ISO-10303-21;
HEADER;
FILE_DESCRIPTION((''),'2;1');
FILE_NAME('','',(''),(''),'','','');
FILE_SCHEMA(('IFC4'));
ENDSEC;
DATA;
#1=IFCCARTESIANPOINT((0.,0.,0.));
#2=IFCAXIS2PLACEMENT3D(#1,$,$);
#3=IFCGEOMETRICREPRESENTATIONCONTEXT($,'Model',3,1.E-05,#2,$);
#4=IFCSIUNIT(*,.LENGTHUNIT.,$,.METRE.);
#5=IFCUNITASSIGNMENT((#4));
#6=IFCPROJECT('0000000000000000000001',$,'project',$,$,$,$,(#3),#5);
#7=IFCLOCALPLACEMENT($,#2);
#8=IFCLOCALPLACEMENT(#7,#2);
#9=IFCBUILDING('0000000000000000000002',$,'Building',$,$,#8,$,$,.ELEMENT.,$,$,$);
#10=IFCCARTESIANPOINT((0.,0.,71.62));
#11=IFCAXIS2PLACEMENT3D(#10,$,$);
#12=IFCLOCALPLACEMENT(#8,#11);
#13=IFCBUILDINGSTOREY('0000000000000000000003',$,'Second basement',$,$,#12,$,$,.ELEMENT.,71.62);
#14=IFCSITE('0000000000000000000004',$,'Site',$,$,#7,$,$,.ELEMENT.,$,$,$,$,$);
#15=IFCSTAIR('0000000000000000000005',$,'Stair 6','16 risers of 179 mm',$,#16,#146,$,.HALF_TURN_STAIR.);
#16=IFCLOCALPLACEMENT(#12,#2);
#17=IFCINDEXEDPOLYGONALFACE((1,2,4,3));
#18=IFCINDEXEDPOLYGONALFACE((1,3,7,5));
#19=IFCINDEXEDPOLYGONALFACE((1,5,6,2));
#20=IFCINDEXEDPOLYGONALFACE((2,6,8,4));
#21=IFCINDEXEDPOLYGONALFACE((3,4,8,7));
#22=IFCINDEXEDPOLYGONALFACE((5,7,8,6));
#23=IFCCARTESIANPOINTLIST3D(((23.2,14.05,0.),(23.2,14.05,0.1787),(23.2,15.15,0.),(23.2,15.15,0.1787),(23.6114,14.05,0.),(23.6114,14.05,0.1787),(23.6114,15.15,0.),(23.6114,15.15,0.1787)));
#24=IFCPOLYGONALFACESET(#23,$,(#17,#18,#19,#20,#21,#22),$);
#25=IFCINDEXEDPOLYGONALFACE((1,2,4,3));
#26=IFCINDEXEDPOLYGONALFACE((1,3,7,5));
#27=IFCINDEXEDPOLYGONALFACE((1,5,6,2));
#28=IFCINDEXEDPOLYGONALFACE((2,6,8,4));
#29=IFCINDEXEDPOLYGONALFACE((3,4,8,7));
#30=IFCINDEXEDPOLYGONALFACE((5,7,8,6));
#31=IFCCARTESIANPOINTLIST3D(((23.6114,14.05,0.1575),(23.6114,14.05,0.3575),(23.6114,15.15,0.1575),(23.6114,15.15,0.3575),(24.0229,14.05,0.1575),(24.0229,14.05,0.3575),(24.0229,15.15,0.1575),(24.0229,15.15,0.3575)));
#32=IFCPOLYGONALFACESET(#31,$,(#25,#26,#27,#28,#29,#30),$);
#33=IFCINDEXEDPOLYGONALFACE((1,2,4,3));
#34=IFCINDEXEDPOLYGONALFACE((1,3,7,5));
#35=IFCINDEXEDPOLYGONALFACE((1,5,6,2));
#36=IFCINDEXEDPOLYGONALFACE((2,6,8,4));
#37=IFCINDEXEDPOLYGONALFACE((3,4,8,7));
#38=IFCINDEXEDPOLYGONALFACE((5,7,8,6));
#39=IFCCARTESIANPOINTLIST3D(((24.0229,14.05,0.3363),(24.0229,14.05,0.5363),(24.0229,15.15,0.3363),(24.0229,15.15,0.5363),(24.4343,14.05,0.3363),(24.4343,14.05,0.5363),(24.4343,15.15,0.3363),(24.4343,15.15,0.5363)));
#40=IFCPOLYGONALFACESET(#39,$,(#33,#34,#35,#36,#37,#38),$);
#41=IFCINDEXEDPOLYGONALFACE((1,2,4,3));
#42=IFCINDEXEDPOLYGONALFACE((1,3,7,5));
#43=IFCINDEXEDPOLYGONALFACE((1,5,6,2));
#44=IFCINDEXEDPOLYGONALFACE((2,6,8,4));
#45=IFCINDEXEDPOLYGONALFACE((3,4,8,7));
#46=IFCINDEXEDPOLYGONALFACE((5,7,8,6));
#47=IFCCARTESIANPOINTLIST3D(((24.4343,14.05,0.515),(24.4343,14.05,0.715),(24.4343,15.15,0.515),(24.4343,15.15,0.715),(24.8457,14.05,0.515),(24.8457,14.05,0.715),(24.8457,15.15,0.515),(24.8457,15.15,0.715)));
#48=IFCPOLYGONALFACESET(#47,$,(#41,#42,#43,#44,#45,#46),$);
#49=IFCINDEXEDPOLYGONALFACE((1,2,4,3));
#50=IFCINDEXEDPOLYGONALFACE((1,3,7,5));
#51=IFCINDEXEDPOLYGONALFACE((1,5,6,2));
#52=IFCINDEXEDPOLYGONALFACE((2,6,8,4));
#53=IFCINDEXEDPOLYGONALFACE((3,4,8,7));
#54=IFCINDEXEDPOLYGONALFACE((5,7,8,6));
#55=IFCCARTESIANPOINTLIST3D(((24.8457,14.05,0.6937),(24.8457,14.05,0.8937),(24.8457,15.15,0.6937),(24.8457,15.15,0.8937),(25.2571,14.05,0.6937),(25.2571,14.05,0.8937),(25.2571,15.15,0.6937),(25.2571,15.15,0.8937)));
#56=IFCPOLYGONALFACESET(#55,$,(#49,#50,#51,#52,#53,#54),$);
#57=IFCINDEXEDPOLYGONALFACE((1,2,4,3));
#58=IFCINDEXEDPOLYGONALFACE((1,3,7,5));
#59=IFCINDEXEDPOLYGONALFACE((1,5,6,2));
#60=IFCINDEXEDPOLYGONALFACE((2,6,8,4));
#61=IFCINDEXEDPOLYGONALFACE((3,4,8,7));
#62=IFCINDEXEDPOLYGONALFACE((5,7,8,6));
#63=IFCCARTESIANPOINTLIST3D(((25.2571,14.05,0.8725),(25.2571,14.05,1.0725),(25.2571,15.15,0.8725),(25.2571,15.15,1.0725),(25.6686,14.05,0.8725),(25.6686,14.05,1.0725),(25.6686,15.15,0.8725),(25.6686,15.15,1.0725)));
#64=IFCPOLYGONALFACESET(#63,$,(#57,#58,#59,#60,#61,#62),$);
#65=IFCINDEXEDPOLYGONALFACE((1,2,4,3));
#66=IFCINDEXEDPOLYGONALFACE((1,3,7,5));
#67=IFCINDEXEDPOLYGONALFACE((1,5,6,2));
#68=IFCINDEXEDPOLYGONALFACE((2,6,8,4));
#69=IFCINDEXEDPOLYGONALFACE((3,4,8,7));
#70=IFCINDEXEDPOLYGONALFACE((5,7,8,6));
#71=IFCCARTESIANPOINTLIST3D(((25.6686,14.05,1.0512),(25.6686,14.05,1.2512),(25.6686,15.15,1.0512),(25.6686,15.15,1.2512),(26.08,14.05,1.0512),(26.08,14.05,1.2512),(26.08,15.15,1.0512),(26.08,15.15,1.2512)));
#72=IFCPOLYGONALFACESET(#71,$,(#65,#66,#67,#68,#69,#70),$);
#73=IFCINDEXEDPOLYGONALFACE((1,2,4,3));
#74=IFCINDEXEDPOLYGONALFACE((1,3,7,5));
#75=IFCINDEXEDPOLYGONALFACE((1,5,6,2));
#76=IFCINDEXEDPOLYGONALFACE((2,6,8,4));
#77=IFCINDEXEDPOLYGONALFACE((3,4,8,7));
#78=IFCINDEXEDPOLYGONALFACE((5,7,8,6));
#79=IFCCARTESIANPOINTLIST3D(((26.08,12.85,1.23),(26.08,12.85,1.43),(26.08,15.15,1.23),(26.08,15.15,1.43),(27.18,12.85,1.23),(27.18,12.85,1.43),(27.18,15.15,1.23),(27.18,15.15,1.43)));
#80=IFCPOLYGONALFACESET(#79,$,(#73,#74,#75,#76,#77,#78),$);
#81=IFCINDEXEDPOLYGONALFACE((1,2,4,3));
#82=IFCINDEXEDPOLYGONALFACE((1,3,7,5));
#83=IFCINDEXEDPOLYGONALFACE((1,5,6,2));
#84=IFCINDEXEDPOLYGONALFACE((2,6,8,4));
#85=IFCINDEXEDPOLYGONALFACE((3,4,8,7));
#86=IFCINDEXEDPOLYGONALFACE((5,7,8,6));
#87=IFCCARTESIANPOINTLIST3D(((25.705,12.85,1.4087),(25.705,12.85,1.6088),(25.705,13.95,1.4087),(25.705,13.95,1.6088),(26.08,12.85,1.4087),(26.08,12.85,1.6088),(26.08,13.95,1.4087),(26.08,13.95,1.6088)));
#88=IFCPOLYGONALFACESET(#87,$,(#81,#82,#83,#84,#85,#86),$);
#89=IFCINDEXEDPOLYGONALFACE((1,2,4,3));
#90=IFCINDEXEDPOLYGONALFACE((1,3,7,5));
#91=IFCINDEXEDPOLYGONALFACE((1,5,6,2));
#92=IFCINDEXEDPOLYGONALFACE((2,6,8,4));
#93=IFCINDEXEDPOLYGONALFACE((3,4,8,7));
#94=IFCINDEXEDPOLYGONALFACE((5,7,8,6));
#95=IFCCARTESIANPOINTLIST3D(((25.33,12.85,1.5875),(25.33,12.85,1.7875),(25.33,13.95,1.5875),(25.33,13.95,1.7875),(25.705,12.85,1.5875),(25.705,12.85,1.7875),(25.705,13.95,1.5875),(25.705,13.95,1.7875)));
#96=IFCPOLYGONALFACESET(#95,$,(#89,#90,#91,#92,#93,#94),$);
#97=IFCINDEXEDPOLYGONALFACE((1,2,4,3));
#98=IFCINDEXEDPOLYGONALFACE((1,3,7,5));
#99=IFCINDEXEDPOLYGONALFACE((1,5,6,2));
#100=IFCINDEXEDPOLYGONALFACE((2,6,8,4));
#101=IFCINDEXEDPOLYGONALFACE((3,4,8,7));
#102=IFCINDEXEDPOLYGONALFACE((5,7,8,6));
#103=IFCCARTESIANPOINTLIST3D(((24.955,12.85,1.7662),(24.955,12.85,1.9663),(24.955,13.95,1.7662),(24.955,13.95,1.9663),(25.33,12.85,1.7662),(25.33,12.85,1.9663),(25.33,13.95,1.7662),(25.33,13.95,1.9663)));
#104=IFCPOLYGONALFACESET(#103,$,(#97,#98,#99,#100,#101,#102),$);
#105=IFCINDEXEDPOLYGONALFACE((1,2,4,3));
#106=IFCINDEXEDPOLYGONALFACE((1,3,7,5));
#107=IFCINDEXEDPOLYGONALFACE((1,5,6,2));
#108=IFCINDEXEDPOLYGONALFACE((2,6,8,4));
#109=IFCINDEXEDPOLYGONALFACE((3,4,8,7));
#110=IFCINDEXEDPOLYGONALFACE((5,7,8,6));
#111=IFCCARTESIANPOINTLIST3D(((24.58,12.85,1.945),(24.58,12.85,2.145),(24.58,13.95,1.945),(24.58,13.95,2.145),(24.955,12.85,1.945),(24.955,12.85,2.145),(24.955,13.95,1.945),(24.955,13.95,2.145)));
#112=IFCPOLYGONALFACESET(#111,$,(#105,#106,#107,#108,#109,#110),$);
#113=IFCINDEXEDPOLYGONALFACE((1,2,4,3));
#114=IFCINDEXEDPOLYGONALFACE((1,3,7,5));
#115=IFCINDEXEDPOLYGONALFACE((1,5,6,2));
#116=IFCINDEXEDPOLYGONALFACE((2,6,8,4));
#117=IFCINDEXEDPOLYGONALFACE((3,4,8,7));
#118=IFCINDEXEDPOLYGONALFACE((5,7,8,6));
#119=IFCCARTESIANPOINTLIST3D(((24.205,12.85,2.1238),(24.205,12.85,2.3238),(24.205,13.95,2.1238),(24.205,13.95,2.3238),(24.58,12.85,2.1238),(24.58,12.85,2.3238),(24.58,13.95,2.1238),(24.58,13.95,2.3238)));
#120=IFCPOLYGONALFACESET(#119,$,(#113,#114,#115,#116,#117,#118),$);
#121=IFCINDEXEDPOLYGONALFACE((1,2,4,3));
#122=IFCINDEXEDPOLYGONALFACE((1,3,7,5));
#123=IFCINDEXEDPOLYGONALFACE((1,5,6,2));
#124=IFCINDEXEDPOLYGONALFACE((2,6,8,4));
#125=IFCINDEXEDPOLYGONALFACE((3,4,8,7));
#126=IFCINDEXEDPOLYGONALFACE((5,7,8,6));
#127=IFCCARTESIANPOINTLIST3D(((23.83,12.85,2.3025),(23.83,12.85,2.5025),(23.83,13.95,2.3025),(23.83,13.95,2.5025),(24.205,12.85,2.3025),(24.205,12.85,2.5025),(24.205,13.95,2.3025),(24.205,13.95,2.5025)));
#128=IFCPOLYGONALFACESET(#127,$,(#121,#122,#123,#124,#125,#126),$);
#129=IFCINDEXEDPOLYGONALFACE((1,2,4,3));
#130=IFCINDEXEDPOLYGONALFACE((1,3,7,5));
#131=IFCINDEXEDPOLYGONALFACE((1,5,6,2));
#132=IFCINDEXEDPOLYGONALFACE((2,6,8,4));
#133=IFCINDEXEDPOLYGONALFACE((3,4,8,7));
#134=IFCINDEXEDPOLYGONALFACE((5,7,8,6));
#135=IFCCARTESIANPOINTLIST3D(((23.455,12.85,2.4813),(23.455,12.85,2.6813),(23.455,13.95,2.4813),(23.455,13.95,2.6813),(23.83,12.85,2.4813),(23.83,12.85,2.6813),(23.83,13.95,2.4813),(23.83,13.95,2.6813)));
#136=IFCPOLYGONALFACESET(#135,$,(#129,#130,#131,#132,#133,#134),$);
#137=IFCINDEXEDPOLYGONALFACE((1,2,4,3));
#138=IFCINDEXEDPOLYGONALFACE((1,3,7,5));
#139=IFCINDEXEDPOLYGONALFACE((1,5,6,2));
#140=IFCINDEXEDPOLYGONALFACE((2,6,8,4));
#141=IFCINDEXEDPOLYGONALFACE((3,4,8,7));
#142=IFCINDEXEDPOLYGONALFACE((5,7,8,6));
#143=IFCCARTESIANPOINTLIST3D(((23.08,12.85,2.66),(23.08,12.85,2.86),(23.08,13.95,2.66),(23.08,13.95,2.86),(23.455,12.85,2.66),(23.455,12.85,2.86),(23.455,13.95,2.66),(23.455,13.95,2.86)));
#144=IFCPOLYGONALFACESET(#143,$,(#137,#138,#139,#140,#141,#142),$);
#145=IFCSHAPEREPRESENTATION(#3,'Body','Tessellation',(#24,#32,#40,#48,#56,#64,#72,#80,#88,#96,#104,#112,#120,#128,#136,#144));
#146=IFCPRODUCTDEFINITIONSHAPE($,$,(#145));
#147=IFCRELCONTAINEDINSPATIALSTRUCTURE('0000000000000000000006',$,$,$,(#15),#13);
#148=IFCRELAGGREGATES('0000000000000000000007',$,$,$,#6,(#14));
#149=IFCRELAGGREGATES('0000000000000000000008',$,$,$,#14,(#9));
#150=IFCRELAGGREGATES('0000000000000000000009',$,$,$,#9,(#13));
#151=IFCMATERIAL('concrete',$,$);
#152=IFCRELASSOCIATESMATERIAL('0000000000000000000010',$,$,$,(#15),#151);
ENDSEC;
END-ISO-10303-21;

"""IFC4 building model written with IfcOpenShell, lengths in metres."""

from ifc_helpers import new_model, si_unit, frame, origin, place, context, project, spatial, polyline, outline, extrude, material, element, save


model = new_model("IFC4")

# Units and contexts
model_context = context("Model", 3, precision=1e-05, world=origin())
ifc_project = project(units=[si_unit("LENGTHUNIT", "METRE")], contexts=[model_context])

# Site, building, storey
site_placement = place(None, origin())
site = spatial("IfcSite", under=ifc_project, at=site_placement, Name="Site", CompositionType="ELEMENT")
building_placement = place(site_placement, origin())
building = spatial("IfcBuilding", under=site, at=building_placement, Name="Building", CompositionType="ELEMENT")
storey_placement = place(building_placement, frame((0.0, 0.0, 71.62)))
storey = spatial("IfcBuildingStorey", under=building, at=storey_placement, Name="Second basement", CompositionType="ELEMENT", Elevation=71.62)

# Shared definitions
ifc_material = material(Name="concrete")

# Stair
stair_1_placement = place(storey_placement, frame((23.2, 14.6, 0.0), z_axis=(0.0, 0.0, 1.0), x_axis=(1.0, 0.0, 0.0)))
element("IfcStair", 1, at=stair_1_placement, inside=storey, material=ifc_material, Name="Stair 6", Description="16 risers of 179 mm", PredefinedType="HALF_TURN_STAIR", context=model_context, shape_type="SweptSolid", body=[
    extrude(outline(polyline([(0.0, -0.55), (0.4114, -0.55), (0.4114, 0.55), (0.0, 0.55), (0.0, -0.55)])), origin(), (0.0, 0.0, 1.0), 0.1787),
    extrude(outline(polyline([(0.4114, -0.55), (0.8229, -0.55), (0.8229, 0.55), (0.4114, 0.55), (0.4114, -0.55)])), frame((0.0, 0.0, 0.1575)), (0.0, 0.0, 1.0), 0.2),
    extrude(outline(polyline([(0.8229, -0.55), (1.2343, -0.55), (1.2343, 0.55), (0.8229, 0.55), (0.8229, -0.55)])), frame((0.0, 0.0, 0.3362)), (0.0, 0.0, 1.0), 0.2),
    extrude(outline(polyline([(1.2343, -0.55), (1.6457, -0.55), (1.6457, 0.55), (1.2343, 0.55), (1.2343, -0.55)])), frame((0.0, 0.0, 0.515)), (0.0, 0.0, 1.0), 0.2),
    extrude(outline(polyline([(1.6457, -0.55), (2.0571, -0.55), (2.0571, 0.55), (1.6457, 0.55), (1.6457, -0.55)])), frame((0.0, 0.0, 0.6937)), (0.0, 0.0, 1.0), 0.2),
    extrude(outline(polyline([(2.0571, -0.55), (2.4686, -0.55), (2.4686, 0.55), (2.0571, 0.55), (2.0571, -0.55)])), frame((0.0, 0.0, 0.8725)), (0.0, 0.0, 1.0), 0.2),
    extrude(outline(polyline([(2.4686, -0.55), (2.88, -0.55), (2.88, 0.55), (2.4686, 0.55), (2.4686, -0.55)])), frame((0.0, 0.0, 1.0513)), (0.0, 0.0, 1.0), 0.2),
    extrude(outline(polyline([(2.88, -1.75), (3.98, -1.75), (3.98, 0.55), (2.88, 0.55), (2.88, -1.75)])), frame((0.0, 0.0, 1.23)), (0.0, 0.0, 1.0), 0.2),
    extrude(outline(polyline([(2.505, -1.75), (2.88, -1.75), (2.88, -0.65), (2.505, -0.65), (2.505, -1.75)])), frame((0.0, 0.0, 1.4087)), (0.0, 0.0, 1.0), 0.2),
    extrude(outline(polyline([(2.13, -1.75), (2.505, -1.75), (2.505, -0.65), (2.13, -0.65), (2.13, -1.75)])), frame((0.0, 0.0, 1.5875)), (0.0, 0.0, 1.0), 0.2),
    extrude(outline(polyline([(1.755, -1.75), (2.13, -1.75), (2.13, -0.65), (1.755, -0.65), (1.755, -1.75)])), frame((0.0, 0.0, 1.7663)), (0.0, 0.0, 1.0), 0.2),
    extrude(outline(polyline([(1.38, -1.75), (1.755, -1.75), (1.755, -0.65), (1.38, -0.65), (1.38, -1.75)])), frame((0.0, 0.0, 1.945)), (0.0, 0.0, 1.0), 0.2),
    extrude(outline(polyline([(1.005, -1.75), (1.38, -1.75), (1.38, -0.65), (1.005, -0.65), (1.005, -1.75)])), frame((0.0, 0.0, 2.1237)), (0.0, 0.0, 1.0), 0.2),
    extrude(outline(polyline([(0.63, -1.75), (1.005, -1.75), (1.005, -0.65), (0.63, -0.65), (0.63, -1.75)])), frame((0.0, 0.0, 2.3025)), (0.0, 0.0, 1.0), 0.2),
    extrude(outline(polyline([(0.255, -1.75), (0.63, -1.75), (0.63, -0.65), (0.255, -0.65), (0.255, -1.75)])), frame((0.0, 0.0, 2.4813)), (0.0, 0.0, 1.0), 0.2),
    extrude(outline(polyline([(-0.12, -1.75), (0.255, -1.75), (0.255, -0.65), (-0.12, -0.65), (-0.12, -1.75)])), frame((0.0, 0.0, 2.66)), (0.0, 0.0, 1.0), 0.2),
])

save(model, "model.ifc")
